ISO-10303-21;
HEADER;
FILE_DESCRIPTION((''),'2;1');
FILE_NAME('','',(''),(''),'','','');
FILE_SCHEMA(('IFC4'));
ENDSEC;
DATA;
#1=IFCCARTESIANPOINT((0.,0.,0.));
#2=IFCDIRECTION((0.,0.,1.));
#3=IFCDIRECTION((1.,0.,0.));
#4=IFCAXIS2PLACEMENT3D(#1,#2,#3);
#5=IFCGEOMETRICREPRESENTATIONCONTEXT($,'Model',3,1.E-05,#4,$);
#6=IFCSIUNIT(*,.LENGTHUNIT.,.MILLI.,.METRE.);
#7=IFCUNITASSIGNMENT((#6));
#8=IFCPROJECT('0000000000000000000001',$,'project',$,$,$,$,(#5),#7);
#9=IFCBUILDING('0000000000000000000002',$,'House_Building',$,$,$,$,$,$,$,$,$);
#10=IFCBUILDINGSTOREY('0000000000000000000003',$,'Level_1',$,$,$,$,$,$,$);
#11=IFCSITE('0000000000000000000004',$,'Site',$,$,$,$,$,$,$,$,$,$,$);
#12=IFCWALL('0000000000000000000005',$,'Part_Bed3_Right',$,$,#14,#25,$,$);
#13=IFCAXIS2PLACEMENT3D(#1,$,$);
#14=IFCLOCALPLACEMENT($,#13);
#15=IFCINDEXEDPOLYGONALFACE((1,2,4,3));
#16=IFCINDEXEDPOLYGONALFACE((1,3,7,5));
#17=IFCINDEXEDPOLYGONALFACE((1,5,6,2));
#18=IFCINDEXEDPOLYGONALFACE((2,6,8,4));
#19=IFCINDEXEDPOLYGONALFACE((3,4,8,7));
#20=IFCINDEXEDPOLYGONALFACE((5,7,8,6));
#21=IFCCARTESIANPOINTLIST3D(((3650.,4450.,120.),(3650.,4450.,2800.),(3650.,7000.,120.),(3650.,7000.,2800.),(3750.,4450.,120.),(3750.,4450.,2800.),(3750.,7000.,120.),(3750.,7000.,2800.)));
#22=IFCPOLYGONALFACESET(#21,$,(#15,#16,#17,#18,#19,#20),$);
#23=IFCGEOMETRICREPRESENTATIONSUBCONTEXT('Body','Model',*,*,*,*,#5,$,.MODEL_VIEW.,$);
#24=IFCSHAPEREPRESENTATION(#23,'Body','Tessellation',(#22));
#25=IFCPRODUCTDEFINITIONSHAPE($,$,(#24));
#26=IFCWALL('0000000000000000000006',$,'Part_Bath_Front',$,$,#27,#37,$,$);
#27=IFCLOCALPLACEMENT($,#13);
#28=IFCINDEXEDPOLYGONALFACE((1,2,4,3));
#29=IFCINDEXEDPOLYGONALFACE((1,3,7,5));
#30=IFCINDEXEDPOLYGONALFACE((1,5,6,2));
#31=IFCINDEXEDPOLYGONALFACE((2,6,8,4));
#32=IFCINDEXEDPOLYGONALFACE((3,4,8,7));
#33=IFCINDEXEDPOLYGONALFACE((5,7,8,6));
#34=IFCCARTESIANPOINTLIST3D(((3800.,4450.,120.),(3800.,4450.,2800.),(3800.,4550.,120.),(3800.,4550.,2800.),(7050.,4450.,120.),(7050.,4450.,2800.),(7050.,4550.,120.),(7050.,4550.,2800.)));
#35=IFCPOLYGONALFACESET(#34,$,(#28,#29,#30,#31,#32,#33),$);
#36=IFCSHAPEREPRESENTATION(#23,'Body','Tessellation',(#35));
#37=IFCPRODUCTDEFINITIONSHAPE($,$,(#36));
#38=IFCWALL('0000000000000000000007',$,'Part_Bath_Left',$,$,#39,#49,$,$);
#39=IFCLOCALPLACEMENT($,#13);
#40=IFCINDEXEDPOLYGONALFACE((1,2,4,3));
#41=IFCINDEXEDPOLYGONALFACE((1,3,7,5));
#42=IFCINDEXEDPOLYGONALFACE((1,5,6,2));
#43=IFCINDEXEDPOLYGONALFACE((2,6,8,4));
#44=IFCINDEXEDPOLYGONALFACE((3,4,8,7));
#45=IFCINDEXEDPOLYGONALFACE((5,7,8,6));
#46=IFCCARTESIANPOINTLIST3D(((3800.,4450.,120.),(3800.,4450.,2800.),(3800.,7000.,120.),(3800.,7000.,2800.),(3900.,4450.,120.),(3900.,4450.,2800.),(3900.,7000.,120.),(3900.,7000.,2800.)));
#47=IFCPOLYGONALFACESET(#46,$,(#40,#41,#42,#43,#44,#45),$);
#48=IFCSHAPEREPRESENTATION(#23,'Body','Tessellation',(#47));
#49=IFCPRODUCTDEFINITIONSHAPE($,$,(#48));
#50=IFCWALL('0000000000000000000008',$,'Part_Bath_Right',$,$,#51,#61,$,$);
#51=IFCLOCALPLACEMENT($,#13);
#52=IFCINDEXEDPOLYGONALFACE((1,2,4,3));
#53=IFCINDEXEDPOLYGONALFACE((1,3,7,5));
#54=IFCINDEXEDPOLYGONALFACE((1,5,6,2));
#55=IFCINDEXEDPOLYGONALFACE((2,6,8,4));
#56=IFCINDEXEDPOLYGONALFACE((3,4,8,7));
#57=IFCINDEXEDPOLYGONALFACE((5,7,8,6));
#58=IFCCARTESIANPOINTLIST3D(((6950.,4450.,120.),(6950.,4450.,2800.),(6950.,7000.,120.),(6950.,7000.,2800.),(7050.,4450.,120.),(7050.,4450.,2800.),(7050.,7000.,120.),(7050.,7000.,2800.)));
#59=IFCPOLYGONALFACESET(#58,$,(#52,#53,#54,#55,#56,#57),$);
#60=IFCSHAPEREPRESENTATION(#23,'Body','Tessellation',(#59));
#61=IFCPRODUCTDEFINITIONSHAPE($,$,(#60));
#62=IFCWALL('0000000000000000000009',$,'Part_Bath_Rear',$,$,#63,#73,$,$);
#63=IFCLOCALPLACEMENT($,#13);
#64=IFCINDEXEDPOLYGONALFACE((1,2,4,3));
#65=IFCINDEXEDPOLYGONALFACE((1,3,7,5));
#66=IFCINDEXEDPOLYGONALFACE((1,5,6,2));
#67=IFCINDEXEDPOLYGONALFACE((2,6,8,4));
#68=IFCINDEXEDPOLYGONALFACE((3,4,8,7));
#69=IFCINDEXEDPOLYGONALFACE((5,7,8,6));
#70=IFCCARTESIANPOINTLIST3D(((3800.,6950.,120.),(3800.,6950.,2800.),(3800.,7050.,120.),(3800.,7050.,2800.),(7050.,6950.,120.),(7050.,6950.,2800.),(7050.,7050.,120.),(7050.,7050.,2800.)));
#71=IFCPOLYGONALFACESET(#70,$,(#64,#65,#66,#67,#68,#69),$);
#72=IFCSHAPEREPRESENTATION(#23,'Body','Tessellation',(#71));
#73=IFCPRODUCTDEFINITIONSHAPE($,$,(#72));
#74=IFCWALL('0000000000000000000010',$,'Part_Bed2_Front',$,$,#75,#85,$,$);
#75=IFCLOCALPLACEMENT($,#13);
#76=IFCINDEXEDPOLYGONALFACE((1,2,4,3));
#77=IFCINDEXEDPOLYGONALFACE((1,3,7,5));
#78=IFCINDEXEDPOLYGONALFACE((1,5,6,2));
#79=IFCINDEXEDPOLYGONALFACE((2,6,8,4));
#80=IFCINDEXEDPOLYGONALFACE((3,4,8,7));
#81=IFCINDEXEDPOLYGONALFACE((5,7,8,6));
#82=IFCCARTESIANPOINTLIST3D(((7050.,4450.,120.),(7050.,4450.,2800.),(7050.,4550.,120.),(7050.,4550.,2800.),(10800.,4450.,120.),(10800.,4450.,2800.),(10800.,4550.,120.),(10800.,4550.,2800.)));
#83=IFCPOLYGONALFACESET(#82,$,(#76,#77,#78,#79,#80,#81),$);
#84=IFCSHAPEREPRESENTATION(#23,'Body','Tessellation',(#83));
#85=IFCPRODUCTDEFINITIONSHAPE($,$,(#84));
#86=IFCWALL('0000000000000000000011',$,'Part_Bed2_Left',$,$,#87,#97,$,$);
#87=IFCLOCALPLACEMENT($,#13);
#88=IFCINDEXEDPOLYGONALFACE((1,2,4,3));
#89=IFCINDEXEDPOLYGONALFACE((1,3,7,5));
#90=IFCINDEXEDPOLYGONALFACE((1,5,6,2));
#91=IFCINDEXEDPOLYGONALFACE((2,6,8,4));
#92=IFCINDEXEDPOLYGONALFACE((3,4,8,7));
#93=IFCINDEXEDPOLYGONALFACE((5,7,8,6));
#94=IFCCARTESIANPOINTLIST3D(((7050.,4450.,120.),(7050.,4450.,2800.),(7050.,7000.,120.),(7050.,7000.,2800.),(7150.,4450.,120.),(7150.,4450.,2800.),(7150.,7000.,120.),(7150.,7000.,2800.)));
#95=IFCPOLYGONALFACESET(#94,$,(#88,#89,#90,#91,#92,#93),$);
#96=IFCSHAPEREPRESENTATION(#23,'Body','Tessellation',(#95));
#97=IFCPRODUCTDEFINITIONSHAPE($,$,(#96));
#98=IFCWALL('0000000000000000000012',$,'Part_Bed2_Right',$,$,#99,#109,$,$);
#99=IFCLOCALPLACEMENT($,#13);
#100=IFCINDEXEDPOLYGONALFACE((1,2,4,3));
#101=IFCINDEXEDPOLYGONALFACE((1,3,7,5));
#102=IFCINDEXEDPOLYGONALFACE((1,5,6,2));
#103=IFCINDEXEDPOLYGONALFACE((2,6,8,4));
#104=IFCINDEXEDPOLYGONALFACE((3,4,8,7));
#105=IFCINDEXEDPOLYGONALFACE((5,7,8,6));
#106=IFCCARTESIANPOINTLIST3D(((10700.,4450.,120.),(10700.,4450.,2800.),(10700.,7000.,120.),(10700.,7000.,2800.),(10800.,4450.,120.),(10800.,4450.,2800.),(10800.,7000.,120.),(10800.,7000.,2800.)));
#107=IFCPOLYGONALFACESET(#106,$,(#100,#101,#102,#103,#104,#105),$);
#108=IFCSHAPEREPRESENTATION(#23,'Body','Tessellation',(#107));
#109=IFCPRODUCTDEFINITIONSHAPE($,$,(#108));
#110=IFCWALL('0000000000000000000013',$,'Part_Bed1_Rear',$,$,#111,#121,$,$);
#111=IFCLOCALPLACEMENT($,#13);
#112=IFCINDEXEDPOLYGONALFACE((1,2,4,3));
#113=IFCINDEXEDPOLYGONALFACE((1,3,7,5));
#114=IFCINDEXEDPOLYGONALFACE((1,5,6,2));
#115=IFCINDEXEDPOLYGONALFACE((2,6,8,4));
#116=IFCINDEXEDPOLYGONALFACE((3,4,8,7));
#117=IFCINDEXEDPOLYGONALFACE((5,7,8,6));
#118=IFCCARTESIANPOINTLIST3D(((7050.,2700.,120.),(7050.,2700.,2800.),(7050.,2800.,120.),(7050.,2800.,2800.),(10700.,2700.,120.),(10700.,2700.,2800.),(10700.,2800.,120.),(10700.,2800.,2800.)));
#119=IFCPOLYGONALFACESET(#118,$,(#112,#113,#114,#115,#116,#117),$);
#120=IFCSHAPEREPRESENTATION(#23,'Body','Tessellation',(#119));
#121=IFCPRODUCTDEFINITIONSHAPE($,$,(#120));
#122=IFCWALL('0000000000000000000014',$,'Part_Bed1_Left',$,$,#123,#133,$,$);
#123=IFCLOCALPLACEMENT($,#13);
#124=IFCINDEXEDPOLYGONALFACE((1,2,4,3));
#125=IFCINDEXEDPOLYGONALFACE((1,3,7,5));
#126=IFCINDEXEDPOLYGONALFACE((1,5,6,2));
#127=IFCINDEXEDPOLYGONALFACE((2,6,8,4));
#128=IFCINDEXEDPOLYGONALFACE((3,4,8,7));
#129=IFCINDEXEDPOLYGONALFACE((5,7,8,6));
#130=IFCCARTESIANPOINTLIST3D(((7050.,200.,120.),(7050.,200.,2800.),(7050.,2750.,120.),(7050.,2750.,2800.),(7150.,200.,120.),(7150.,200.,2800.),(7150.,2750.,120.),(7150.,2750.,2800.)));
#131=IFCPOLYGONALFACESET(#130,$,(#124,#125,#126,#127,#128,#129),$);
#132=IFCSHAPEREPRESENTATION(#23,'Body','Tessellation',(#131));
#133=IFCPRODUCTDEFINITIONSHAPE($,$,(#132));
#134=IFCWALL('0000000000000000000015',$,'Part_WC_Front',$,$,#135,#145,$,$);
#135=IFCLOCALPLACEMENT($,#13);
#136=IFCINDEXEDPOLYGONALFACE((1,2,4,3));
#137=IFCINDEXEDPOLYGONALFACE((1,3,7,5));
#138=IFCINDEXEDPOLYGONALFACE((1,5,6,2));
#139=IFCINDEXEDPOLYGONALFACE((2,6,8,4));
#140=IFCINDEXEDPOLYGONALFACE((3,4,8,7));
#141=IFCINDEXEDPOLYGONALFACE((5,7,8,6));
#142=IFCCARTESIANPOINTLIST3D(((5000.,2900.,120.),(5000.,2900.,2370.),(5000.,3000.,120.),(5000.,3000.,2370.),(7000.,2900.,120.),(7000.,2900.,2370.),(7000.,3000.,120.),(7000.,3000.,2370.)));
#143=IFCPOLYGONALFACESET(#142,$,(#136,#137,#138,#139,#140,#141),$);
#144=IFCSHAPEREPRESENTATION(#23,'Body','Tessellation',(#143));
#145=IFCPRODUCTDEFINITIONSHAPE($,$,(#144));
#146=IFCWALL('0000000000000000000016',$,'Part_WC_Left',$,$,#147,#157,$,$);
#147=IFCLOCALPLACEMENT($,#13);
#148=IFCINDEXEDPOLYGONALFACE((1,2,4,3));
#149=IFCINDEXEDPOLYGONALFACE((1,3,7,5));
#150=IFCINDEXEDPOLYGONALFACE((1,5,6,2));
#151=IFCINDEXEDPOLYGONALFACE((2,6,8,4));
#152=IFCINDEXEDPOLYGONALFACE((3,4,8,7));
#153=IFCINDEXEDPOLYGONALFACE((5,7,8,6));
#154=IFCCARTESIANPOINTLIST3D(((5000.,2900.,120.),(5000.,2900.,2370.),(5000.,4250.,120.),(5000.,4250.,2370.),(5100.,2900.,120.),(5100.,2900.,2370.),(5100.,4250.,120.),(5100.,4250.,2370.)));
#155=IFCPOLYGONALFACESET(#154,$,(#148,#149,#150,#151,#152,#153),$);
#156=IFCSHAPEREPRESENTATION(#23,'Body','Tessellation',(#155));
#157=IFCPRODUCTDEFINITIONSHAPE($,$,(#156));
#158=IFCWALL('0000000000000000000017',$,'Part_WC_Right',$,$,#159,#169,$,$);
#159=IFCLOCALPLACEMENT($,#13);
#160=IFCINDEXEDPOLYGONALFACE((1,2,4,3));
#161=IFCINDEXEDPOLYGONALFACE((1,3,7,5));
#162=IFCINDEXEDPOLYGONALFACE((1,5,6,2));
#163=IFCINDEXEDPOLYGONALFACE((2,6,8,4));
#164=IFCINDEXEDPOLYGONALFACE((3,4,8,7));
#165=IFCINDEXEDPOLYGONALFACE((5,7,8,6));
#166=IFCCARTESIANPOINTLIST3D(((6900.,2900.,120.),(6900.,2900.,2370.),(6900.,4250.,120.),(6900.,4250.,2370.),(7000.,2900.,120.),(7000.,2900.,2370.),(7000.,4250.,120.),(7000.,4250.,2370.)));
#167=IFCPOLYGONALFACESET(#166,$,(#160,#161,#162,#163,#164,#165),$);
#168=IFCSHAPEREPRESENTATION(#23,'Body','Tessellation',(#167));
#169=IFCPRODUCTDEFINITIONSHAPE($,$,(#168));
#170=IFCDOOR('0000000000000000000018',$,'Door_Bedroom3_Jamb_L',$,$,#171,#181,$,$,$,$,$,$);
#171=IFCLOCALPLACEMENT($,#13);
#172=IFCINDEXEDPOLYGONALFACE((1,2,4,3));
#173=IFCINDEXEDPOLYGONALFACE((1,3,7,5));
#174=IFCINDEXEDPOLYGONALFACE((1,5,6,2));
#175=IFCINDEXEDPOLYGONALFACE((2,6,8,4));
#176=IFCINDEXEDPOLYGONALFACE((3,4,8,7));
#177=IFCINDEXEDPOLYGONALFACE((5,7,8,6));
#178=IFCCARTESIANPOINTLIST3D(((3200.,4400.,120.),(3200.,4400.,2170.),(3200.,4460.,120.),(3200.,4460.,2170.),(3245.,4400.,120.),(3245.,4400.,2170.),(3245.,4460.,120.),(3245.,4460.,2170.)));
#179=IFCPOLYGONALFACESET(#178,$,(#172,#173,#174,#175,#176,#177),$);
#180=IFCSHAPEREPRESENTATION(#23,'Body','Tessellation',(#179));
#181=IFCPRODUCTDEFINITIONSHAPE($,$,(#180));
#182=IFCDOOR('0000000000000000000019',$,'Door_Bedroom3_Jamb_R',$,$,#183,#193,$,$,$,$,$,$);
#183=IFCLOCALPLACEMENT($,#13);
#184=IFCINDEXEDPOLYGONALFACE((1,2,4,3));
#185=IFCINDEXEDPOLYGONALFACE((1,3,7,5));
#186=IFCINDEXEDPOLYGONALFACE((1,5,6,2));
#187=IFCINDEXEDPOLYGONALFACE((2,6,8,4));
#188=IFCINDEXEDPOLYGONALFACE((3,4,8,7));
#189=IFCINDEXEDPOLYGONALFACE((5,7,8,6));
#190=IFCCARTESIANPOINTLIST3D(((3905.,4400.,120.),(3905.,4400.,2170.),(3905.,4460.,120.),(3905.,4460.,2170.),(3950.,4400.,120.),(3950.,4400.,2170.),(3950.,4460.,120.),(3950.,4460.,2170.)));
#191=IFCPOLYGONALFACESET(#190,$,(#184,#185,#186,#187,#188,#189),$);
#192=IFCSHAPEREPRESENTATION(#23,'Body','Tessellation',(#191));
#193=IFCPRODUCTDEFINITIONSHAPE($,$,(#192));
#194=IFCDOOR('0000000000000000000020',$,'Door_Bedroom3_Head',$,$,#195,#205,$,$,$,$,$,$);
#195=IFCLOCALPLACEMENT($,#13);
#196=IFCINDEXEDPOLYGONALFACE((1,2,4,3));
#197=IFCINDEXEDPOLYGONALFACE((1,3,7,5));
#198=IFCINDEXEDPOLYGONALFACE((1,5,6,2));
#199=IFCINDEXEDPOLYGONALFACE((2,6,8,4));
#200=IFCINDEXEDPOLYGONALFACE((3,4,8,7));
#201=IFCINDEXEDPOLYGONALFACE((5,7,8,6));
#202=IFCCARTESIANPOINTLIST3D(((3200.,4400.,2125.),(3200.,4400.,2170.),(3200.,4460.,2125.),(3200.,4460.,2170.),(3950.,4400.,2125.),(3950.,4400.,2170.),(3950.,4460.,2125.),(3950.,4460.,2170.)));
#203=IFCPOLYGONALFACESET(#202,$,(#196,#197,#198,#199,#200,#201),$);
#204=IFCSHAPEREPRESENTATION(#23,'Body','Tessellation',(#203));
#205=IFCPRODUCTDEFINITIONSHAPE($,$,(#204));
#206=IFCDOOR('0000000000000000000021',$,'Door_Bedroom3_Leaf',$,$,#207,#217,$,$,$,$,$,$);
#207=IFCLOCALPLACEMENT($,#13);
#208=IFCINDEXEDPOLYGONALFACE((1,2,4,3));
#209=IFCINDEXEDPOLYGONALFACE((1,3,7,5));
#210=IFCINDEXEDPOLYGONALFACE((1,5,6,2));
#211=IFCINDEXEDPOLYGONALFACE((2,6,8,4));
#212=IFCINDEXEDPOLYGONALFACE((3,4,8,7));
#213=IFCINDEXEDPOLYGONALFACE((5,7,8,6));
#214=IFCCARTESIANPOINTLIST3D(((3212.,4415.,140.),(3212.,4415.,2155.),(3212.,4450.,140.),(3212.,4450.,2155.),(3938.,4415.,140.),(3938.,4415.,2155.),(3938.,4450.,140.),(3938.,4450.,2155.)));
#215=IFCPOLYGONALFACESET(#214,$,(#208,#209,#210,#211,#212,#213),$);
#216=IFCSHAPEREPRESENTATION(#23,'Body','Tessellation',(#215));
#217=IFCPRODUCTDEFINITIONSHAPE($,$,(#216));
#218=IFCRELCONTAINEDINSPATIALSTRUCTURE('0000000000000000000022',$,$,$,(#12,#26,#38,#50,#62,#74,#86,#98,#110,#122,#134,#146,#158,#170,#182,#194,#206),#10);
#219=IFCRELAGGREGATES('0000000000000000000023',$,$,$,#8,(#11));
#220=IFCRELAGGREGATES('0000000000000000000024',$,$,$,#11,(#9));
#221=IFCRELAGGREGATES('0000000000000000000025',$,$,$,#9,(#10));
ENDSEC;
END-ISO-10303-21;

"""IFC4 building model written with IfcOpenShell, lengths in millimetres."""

from ifc_helpers import new_model, si_unit, frame, origin_with_axes, context, subcontext, project, spatial, polyline, outline, extrude, element, save


model = new_model("IFC4")

# Units and contexts
model_context = context("Model", 3, precision=1e-05, world=origin_with_axes())
body_context = subcontext(model_context, "Body", "Model", "MODEL_VIEW")
ifc_project = project(units=[si_unit("LENGTHUNIT", "METRE", prefix="MILLI")], contexts=[model_context])

# Site, building, storey
site = spatial("IfcSite", under=ifc_project, Name="Site")
building = spatial("IfcBuilding", under=site, Name="House_Building")
storey = spatial("IfcBuildingStorey", under=building, Name="Level_1")

# Walls
element("IfcWall", 1, inside=storey, Name="Part_Bed3_Right", context=body_context, shape_type="SweptSolid", body=[
    extrude(outline(polyline([(3650.0, 4450.0), (3750.0, 4450.0), (3750.0, 7000.0), (3650.0, 7000.0), (3650.0, 4450.0)])), frame((0.0, 0.0, 120.0), z_axis=(0.0, 0.0, 1.0), x_axis=(1.0, 0.0, 0.0)), (0.0, 0.0, 1.0), 2680.0),
])
element("IfcWall", 2, inside=storey, Name="Part_Bath_Front", context=body_context, shape_type="SweptSolid", body=[
    extrude(outline(polyline([(3800.0, 4450.0), (7050.0, 4450.0), (7050.0, 4550.0), (3800.0, 4550.0), (3800.0, 4450.0)])), frame((0.0, 0.0, 120.0), z_axis=(0.0, 0.0, 1.0), x_axis=(1.0, 0.0, 0.0)), (0.0, 0.0, 1.0), 2680.0),
])
element("IfcWall", 3, inside=storey, Name="Part_Bath_Left", context=body_context, shape_type="SweptSolid", body=[
    extrude(outline(polyline([(3800.0, 4450.0), (3900.0, 4450.0), (3900.0, 7000.0), (3800.0, 7000.0), (3800.0, 4450.0)])), frame((0.0, 0.0, 120.0), z_axis=(0.0, 0.0, 1.0), x_axis=(1.0, 0.0, 0.0)), (0.0, 0.0, 1.0), 2680.0),
])
element("IfcWall", 4, inside=storey, Name="Part_Bath_Right", context=body_context, shape_type="SweptSolid", body=[
    extrude(outline(polyline([(6950.0, 4450.0), (7050.0, 4450.0), (7050.0, 7000.0), (6950.0, 7000.0), (6950.0, 4450.0)])), frame((0.0, 0.0, 120.0), z_axis=(0.0, 0.0, 1.0), x_axis=(1.0, 0.0, 0.0)), (0.0, 0.0, 1.0), 2680.0),
])
element("IfcWall", 5, inside=storey, Name="Part_Bath_Rear", context=body_context, shape_type="SweptSolid", body=[
    extrude(outline(polyline([(3800.0, 6950.0), (7050.0, 6950.0), (7050.0, 7050.0), (3800.0, 7050.0), (3800.0, 6950.0)])), frame((0.0, 0.0, 120.0), z_axis=(0.0, 0.0, 1.0), x_axis=(1.0, 0.0, 0.0)), (0.0, 0.0, 1.0), 2680.0),
])
element("IfcWall", 6, inside=storey, Name="Part_Bed2_Front", context=body_context, shape_type="SweptSolid", body=[
    extrude(outline(polyline([(7050.0, 4450.0), (10800.0, 4450.0), (10800.0, 4550.0), (7050.0, 4550.0), (7050.0, 4450.0)])), frame((0.0, 0.0, 120.0), z_axis=(0.0, 0.0, 1.0), x_axis=(1.0, 0.0, 0.0)), (0.0, 0.0, 1.0), 2680.0),
])
element("IfcWall", 7, inside=storey, Name="Part_Bed2_Left", context=body_context, shape_type="SweptSolid", body=[
    extrude(outline(polyline([(7050.0, 4450.0), (7150.0, 4450.0), (7150.0, 7000.0), (7050.0, 7000.0), (7050.0, 4450.0)])), frame((0.0, 0.0, 120.0), z_axis=(0.0, 0.0, 1.0), x_axis=(1.0, 0.0, 0.0)), (0.0, 0.0, 1.0), 2680.0),
])
element("IfcWall", 8, inside=storey, Name="Part_Bed2_Right", context=body_context, shape_type="SweptSolid", body=[
    extrude(outline(polyline([(10700.0, 4450.0), (10800.0, 4450.0), (10800.0, 7000.0), (10700.0, 7000.0), (10700.0, 4450.0)])), frame((0.0, 0.0, 120.0), z_axis=(0.0, 0.0, 1.0), x_axis=(1.0, 0.0, 0.0)), (0.0, 0.0, 1.0), 2680.0),
])
element("IfcWall", 9, inside=storey, Name="Part_Bed1_Rear", context=body_context, shape_type="SweptSolid", body=[
    extrude(outline(polyline([(7050.0, 2700.0), (10700.0, 2700.0), (10700.0, 2800.0), (7050.0, 2800.0), (7050.0, 2700.0)])), frame((0.0, 0.0, 120.0), z_axis=(0.0, 0.0, 1.0), x_axis=(1.0, 0.0, 0.0)), (0.0, 0.0, 1.0), 2680.0),
])
element("IfcWall", 10, inside=storey, Name="Part_Bed1_Left", context=body_context, shape_type="SweptSolid", body=[
    extrude(outline(polyline([(7050.0, 200.0), (7150.0, 200.0), (7150.0, 2750.0), (7050.0, 2750.0), (7050.0, 200.0)])), frame((0.0, 0.0, 120.0), z_axis=(0.0, 0.0, 1.0), x_axis=(1.0, 0.0, 0.0)), (0.0, 0.0, 1.0), 2680.0),
])
element("IfcWall", 11, inside=storey, Name="Part_WC_Front", context=body_context, shape_type="SweptSolid", body=[
    extrude(outline(polyline([(5000.0, 2900.0), (7000.0, 2900.0), (7000.0, 3000.0), (5000.0, 3000.0), (5000.0, 2900.0)])), frame((0.0, 0.0, 120.0), z_axis=(0.0, 0.0, 1.0), x_axis=(1.0, 0.0, 0.0)), (0.0, 0.0, 1.0), 2250.0),
])
element("IfcWall", 12, inside=storey, Name="Part_WC_Left", context=body_context, shape_type="SweptSolid", body=[
    extrude(outline(polyline([(5000.0, 2900.0), (5100.0, 2900.0), (5100.0, 4250.0), (5000.0, 4250.0), (5000.0, 2900.0)])), frame((0.0, 0.0, 120.0), z_axis=(0.0, 0.0, 1.0), x_axis=(1.0, 0.0, 0.0)), (0.0, 0.0, 1.0), 2250.0),
])
element("IfcWall", 13, inside=storey, Name="Part_WC_Right", context=body_context, shape_type="SweptSolid", body=[
    extrude(outline(polyline([(6900.0, 2900.0), (7000.0, 2900.0), (7000.0, 4250.0), (6900.0, 4250.0), (6900.0, 2900.0)])), frame((0.0, 0.0, 120.0), z_axis=(0.0, 0.0, 1.0), x_axis=(1.0, 0.0, 0.0)), (0.0, 0.0, 1.0), 2250.0),
])

# Doors
element("IfcDoor", 14, inside=storey, Name="Door_Bedroom3_Jamb_L", context=body_context, shape_type="SweptSolid", body=[
    extrude(outline(polyline([(3200.0, 4400.0), (3245.0, 4400.0), (3245.0, 4460.0), (3200.0, 4460.0), (3200.0, 4400.0)])), frame((0.0, 0.0, 120.0), z_axis=(0.0, 0.0, 1.0), x_axis=(1.0, 0.0, 0.0)), (0.0, 0.0, 1.0), 2050.0),
])
element("IfcDoor", 15, inside=storey, Name="Door_Bedroom3_Jamb_R", context=body_context, shape_type="SweptSolid", body=[
    extrude(outline(polyline([(3905.0, 4400.0), (3950.0, 4400.0), (3950.0, 4460.0), (3905.0, 4460.0), (3905.0, 4400.0)])), frame((0.0, 0.0, 120.0), z_axis=(0.0, 0.0, 1.0), x_axis=(1.0, 0.0, 0.0)), (0.0, 0.0, 1.0), 2050.0),
])
element("IfcDoor", 16, inside=storey, Name="Door_Bedroom3_Head", context=body_context, shape_type="SweptSolid", body=[
    extrude(outline(polyline([(3200.0, 4400.0), (3950.0, 4400.0), (3950.0, 4460.0), (3200.0, 4460.0), (3200.0, 4400.0)])), frame((0.0, 0.0, 2125.0), z_axis=(0.0, 0.0, 1.0), x_axis=(1.0, 0.0, 0.0)), (0.0, 0.0, 1.0), 45.0),
])
element("IfcDoor", 17, inside=storey, Name="Door_Bedroom3_Leaf", context=body_context, shape_type="SweptSolid", body=[
    extrude(outline(polyline([(3212.0, 4415.0), (3938.0, 4415.0), (3938.0, 4450.0), (3212.0, 4450.0), (3212.0, 4415.0)])), frame((0.0, 0.0, 140.0), z_axis=(0.0, 0.0, 1.0), x_axis=(1.0, 0.0, 0.0)), (0.0, 0.0, 1.0), 2015.0),
])

save(model, "model.ifc")
